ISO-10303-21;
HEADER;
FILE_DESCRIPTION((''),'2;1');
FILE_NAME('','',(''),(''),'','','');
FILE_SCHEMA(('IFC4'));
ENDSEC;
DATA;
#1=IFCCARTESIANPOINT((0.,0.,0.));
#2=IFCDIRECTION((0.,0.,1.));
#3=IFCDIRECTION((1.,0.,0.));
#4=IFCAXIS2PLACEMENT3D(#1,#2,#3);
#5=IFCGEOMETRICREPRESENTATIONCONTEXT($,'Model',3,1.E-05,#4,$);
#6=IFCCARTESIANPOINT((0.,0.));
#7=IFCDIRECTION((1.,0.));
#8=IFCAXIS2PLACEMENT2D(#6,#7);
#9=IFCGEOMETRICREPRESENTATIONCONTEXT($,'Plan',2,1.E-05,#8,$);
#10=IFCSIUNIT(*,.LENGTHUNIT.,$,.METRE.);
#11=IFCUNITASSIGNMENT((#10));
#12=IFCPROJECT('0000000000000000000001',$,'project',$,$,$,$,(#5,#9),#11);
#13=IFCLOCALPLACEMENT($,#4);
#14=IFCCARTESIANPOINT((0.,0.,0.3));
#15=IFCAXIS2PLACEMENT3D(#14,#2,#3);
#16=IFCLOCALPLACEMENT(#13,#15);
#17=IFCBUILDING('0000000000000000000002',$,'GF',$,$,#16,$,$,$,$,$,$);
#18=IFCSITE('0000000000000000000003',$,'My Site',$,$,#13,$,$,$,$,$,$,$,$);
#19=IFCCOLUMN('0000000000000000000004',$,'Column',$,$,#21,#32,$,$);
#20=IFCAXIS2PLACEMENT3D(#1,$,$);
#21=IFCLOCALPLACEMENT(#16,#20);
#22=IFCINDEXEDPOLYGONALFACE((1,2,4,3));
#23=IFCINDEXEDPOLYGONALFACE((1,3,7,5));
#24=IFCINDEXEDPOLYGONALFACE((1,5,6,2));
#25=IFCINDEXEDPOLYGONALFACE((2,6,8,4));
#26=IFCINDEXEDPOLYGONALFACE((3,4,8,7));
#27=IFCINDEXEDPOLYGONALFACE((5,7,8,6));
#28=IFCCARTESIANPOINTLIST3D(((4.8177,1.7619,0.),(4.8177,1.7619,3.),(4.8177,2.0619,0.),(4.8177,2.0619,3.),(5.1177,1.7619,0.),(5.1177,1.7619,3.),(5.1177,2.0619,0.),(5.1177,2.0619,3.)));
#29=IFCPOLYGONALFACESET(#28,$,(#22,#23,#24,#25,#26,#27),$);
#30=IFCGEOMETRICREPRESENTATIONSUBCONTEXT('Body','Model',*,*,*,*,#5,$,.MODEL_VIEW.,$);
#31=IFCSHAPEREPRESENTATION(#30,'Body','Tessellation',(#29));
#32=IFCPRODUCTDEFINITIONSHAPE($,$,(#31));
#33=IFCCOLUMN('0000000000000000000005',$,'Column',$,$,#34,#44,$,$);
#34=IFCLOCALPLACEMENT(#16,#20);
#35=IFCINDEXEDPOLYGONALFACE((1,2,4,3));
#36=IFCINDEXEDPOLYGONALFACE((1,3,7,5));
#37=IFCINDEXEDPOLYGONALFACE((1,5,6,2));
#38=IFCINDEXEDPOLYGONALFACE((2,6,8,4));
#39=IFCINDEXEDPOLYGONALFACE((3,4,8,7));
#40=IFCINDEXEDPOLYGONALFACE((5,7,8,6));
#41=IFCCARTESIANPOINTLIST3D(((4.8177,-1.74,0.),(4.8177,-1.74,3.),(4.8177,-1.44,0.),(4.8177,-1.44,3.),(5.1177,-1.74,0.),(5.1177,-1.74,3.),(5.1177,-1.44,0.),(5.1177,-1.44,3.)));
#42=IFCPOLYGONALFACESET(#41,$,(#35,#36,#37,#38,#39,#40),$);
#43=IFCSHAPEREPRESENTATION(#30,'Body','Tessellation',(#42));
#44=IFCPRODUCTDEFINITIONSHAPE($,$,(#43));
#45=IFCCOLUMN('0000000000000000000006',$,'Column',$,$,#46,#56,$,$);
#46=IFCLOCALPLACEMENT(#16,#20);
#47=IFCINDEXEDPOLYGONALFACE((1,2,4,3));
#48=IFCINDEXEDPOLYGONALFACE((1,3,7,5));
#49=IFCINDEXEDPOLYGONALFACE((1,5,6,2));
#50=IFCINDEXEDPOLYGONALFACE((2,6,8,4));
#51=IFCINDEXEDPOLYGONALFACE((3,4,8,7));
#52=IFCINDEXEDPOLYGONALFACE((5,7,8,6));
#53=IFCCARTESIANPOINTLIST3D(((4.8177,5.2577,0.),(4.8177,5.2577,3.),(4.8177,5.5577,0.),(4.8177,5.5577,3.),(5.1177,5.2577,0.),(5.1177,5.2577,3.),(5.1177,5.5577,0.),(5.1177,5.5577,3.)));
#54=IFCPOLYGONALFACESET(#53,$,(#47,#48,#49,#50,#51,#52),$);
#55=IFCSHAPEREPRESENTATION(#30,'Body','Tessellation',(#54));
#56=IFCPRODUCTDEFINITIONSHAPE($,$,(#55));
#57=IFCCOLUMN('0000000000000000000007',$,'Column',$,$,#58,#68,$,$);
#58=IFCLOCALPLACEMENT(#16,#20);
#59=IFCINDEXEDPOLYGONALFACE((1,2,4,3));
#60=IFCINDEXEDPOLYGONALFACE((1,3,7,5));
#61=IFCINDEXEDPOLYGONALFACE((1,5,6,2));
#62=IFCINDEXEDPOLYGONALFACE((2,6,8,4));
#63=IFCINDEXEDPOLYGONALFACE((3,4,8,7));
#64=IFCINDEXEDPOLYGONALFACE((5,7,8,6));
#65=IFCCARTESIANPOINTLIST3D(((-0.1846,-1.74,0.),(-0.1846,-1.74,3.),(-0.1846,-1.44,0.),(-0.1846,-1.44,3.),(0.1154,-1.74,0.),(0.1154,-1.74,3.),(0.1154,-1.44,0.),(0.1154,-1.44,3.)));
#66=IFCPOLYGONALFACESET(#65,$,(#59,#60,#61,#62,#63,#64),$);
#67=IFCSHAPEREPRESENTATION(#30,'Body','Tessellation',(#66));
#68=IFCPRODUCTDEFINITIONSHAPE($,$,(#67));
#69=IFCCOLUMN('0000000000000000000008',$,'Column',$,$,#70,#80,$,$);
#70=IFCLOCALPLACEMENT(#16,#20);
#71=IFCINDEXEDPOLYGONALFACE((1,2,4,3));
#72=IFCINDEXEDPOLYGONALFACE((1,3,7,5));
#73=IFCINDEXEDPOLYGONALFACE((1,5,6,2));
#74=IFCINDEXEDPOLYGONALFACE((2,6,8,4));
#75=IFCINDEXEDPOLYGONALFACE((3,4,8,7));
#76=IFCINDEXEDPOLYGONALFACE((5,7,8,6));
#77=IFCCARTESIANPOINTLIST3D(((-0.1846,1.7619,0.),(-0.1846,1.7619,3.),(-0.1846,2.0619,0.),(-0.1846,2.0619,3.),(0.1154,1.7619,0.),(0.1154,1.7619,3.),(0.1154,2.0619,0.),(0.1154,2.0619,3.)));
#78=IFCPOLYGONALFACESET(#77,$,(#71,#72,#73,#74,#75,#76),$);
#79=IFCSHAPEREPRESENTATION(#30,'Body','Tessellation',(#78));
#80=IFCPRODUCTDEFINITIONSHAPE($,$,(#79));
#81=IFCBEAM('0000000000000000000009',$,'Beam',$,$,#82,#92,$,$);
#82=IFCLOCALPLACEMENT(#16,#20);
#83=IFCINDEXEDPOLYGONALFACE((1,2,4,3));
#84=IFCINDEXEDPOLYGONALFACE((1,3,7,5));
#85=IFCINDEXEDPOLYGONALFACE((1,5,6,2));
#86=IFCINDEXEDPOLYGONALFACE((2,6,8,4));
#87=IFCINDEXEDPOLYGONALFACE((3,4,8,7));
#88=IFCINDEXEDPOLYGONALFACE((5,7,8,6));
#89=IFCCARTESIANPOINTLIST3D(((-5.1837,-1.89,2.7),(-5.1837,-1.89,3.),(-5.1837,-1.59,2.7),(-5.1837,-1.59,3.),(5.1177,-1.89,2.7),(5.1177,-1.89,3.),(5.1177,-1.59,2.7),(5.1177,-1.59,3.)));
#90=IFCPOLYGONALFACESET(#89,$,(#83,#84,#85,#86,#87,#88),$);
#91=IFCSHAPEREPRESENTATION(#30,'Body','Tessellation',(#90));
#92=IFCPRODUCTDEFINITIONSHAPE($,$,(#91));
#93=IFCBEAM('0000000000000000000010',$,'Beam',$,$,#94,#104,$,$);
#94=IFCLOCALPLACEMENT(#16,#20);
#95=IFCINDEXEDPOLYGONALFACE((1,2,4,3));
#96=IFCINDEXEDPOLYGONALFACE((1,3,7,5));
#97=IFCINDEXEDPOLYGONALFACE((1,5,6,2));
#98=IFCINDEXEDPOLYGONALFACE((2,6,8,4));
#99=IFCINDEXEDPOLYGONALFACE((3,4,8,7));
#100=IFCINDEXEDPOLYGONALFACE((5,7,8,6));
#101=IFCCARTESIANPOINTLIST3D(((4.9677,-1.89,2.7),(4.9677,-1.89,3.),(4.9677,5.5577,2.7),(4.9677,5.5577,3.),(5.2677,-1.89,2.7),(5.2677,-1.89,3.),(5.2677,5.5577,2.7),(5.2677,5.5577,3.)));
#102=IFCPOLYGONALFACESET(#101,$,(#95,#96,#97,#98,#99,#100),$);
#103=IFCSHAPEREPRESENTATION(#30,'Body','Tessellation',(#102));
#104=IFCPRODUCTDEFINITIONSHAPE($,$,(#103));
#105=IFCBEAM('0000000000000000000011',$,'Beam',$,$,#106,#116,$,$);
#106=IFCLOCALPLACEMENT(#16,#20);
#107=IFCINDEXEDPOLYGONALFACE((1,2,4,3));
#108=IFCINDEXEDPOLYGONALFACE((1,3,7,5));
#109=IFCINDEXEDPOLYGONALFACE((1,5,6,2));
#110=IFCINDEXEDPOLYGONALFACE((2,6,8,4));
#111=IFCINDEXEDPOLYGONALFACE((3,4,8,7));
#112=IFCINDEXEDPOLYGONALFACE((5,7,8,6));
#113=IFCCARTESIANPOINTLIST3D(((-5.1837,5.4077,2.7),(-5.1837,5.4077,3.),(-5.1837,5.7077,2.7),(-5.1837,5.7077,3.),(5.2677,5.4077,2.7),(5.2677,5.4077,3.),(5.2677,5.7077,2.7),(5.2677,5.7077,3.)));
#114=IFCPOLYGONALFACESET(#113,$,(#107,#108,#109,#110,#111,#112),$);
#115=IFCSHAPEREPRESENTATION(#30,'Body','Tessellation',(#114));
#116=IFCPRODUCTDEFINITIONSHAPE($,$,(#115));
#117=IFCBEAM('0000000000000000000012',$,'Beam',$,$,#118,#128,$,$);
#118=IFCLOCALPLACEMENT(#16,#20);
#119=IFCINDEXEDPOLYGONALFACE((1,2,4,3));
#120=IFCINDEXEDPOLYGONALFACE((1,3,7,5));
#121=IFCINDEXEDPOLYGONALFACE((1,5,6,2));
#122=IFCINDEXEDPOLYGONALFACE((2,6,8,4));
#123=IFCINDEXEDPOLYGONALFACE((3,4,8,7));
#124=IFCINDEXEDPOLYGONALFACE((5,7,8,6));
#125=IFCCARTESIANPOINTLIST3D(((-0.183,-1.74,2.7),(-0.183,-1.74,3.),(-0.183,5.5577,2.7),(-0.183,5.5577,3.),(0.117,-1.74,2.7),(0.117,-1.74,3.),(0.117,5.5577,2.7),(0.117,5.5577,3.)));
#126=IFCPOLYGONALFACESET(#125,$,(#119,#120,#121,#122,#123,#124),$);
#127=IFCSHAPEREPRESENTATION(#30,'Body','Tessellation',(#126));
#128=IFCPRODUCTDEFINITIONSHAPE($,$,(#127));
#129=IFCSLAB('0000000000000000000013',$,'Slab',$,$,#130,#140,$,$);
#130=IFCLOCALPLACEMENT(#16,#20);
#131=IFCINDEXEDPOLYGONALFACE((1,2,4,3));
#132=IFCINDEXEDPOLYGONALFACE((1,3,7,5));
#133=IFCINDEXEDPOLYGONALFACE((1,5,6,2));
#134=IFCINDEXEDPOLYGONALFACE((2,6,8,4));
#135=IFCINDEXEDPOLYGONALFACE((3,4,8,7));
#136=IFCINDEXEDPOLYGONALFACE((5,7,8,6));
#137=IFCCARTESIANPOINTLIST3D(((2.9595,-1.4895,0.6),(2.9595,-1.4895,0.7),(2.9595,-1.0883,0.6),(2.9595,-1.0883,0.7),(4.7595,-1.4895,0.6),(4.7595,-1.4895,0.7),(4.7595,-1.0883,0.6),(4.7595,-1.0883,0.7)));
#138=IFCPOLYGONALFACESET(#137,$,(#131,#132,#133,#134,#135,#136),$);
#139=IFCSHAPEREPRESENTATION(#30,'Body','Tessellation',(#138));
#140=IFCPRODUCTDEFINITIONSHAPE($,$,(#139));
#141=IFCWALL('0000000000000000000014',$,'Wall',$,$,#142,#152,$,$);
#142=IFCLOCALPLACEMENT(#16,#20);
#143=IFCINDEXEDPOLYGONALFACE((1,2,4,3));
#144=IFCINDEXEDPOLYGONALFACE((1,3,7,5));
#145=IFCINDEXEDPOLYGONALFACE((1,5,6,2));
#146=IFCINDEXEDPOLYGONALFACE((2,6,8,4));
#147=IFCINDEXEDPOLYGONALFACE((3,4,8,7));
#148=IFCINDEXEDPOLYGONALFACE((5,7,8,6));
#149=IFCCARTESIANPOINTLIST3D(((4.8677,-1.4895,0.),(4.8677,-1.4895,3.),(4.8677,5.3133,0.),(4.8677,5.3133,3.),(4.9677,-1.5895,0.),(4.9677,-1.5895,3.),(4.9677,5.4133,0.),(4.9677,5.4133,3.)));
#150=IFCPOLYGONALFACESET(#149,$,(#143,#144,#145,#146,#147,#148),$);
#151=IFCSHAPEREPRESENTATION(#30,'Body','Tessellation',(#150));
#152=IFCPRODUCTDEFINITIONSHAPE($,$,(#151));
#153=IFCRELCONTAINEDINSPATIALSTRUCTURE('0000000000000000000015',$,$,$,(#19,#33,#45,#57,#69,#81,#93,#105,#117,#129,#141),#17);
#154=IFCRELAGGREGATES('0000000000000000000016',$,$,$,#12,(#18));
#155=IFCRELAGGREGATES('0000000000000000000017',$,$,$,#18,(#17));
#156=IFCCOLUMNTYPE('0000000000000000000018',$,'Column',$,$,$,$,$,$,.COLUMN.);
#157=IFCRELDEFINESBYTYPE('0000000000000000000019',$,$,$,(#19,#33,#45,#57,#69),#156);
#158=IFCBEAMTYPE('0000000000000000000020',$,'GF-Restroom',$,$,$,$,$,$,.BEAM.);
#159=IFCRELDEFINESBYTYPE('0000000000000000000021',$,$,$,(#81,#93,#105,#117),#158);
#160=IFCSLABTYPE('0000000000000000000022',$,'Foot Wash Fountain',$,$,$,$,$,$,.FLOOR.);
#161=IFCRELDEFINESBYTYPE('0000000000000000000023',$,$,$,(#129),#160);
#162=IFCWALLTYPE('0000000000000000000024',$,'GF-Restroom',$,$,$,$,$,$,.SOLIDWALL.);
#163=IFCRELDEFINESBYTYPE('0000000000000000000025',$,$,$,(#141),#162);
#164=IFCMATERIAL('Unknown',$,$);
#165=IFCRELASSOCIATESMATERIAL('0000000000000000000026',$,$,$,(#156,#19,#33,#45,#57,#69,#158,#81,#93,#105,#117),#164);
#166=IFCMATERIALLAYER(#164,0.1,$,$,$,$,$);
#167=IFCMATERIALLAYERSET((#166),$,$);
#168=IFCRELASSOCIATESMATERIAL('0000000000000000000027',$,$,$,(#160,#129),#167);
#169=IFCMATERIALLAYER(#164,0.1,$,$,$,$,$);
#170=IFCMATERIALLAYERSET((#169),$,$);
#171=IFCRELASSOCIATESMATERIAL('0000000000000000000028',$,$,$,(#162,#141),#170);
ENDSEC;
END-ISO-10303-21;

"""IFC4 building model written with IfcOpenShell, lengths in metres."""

from ifc_helpers import new_model, si_unit, frame, origin_with_axes, origin_2d_with_axis, place, context, subcontext, project, spatial, line, indexed_curve, rectangle, outline, extrude, material, layer, layer_set, layer_usage, material_profile, profile_set, profile_usage, type_object, element, save


model = new_model("IFC4")

# Units and contexts
model_context = context("Model", 3, precision=1e-05, world=origin_with_axes())
plan_context = context("Plan", 2, precision=1e-05, world=origin_2d_with_axis())
body_context_1 = subcontext(model_context, "Body", "Model", "MODEL_VIEW")
ifc_project = project(units=[si_unit("LENGTHUNIT", "METRE")], contexts=[model_context, plan_context])

# Site, building
site_placement = place(None, origin_with_axes())
site = spatial("IfcSite", under=ifc_project, at=site_placement, Name="My Site")
building_placement = place(site_placement, frame((0.0, 0.0, 0.3), z_axis=(0.0, 0.0, 1.0), x_axis=(1.0, 0.0, 0.0)))
building = spatial("IfcBuilding", under=site, at=building_placement, Name="GF")

# Columns
ifc_material = material(Name="Unknown")
ifc_material_profile_1 = material_profile(ifc_material, rectangle(XDim=0.3, YDim=0.3))
ifc_profile_set_1 = profile_set([ifc_material_profile_1])
ifc_profile_usage_1 = profile_usage(ifc_profile_set_1, cardinal=5)
column_type = type_object("IfcColumnType", Name="Column", PredefinedType="COLUMN", material=ifc_profile_set_1)
column_1_placement = place(building_placement, frame((4.9677, 1.9119, 0.0), z_axis=(0.0, 0.0, 1.0), x_axis=(1.0, 0.0, 0.0)))
element("IfcColumn", 1, at=column_1_placement, inside=building, type_object=column_type, material=ifc_profile_usage_1, Name="Column", context=body_context_1, shape_type="SweptSolid", body=[
    extrude(rectangle(XDim=0.3, YDim=0.3), origin_with_axes(), (0.0, 0.0, 1.0), 3.0),
])
ifc_profile_usage_2 = profile_usage(ifc_profile_set_1, cardinal=5)
column_2_placement = place(building_placement, frame((4.9677, -1.59, 0.0), z_axis=(0.0, 0.0, 1.0), x_axis=(1.0, 0.0, 0.0)))
element("IfcColumn", 2, at=column_2_placement, inside=building, type_object=column_type, material=ifc_profile_usage_2, Name="Column", context=body_context_1, shape_type="SweptSolid", body=[
    extrude(rectangle(XDim=0.3, YDim=0.3), origin_with_axes(), (0.0, 0.0, 1.0), 3.0),
])
ifc_profile_usage_3 = profile_usage(ifc_profile_set_1, cardinal=5)
column_3_placement = place(building_placement, frame((4.9677, 5.4077, 0.0), z_axis=(0.0, 0.0, 1.0), x_axis=(1.0, 0.0, 0.0)))
element("IfcColumn", 3, at=column_3_placement, inside=building, type_object=column_type, material=ifc_profile_usage_3, Name="Column", context=body_context_1, shape_type="SweptSolid", body=[
    extrude(rectangle(XDim=0.3, YDim=0.3), origin_with_axes(), (0.0, 0.0, 1.0), 3.0),
])
ifc_profile_usage_4 = profile_usage(ifc_profile_set_1, cardinal=5)
column_4_placement = place(building_placement, frame((-0.0346, -1.59, 0.0), z_axis=(0.0, 0.0, 1.0), x_axis=(1.0, 0.0, 0.0)))
element("IfcColumn", 4, at=column_4_placement, inside=building, type_object=column_type, material=ifc_profile_usage_4, Name="Column", context=body_context_1, shape_type="SweptSolid", body=[
    extrude(rectangle(XDim=0.3, YDim=0.3), origin_with_axes(), (0.0, 0.0, 1.0), 3.0),
])
ifc_profile_usage_5 = profile_usage(ifc_profile_set_1, cardinal=5)
column_5_placement = place(building_placement, frame((-0.0346, 1.9119, 0.0), z_axis=(0.0, 0.0, 1.0), x_axis=(1.0, 0.0, 0.0)))
element("IfcColumn", 5, at=column_5_placement, inside=building, type_object=column_type, material=ifc_profile_usage_5, Name="Column", context=body_context_1, shape_type="SweptSolid", body=[
    extrude(rectangle(XDim=0.3, YDim=0.3), origin_with_axes(), (0.0, 0.0, 1.0), 3.0),
])

# Beams
ifc_material_profile_2 = material_profile(ifc_material, rectangle(XDim=0.3, YDim=0.3))
ifc_profile_set_2 = profile_set([ifc_material_profile_2])
ifc_profile_usage_6 = profile_usage(ifc_profile_set_2, cardinal=8)
beam_type = type_object("IfcBeamType", Name="GF-Restroom", PredefinedType="BEAM", material=ifc_profile_set_2)
beam_1_placement = place(building_placement, frame((5.1177, -1.74, 3.0), z_axis=(-1.0, 0.0, 0.0), x_axis=(0.0, -1.0, 0.0)))
element("IfcBeam", 6, at=beam_1_placement, inside=building, type_object=beam_type, material=ifc_profile_usage_6, Name="Beam", context=body_context_1, shape_type="SweptSolid", body=[
    extrude(rectangle(XDim=0.3, YDim=0.3), frame((0.0, -0.15, 0.0), z_axis=(0.0, 0.0, 1.0), x_axis=(1.0, 0.0, 0.0)), (0.0, 0.0, 1.0), 10.3015),
])
ifc_profile_usage_7 = profile_usage(ifc_profile_set_2, cardinal=8)
beam_2_placement = place(building_placement, frame((5.1177, -1.89, 3.0), z_axis=(0.0, 1.0, 0.0), x_axis=(-1.0, 0.0, 0.0)))
element("IfcBeam", 7, at=beam_2_placement, inside=building, type_object=beam_type, material=ifc_profile_usage_7, Name="Beam", context=body_context_1, shape_type="SweptSolid", body=[
    extrude(rectangle(XDim=0.3, YDim=0.3), frame((0.0, -0.15, 0.0), z_axis=(0.0, 0.0, 1.0), x_axis=(1.0, 0.0, 0.0)), (0.0, 0.0, 1.0), 7.4477),
])
ifc_profile_usage_8 = profile_usage(ifc_profile_set_2, cardinal=8)
beam_3_placement = place(building_placement, frame((5.2677, 5.5577, 3.0), z_axis=(-1.0, 0.0, 0.0), x_axis=(0.0, -1.0, 0.0)))
element("IfcBeam", 8, at=beam_3_placement, inside=building, type_object=beam_type, material=ifc_profile_usage_8, Name="Beam", context=body_context_1, shape_type="SweptSolid", body=[
    extrude(rectangle(XDim=0.3, YDim=0.3), frame((0.0, -0.15, 0.0), z_axis=(0.0, 0.0, 1.0), x_axis=(1.0, 0.0, 0.0)), (0.0, 0.0, 1.0), 10.4515),
])
ifc_profile_usage_9 = profile_usage(ifc_profile_set_2, cardinal=8)
beam_4_placement = place(building_placement, frame((-0.033, -1.74, 3.0), z_axis=(0.0, 1.0, 0.0), x_axis=(-1.0, 0.0, 0.0)))
element("IfcBeam", 9, at=beam_4_placement, inside=building, type_object=beam_type, material=ifc_profile_usage_9, Name="Beam", context=body_context_1, shape_type="SweptSolid", body=[
    extrude(rectangle(XDim=0.3, YDim=0.3), frame((0.0, -0.15, 0.0), z_axis=(0.0, 0.0, 1.0), x_axis=(1.0, 0.0, 0.0)), (0.0, 0.0, 1.0), 7.2977),
])

# Slab
ifc_layer_1 = layer(ifc_material, 0.1)
ifc_layer_set_1 = layer_set([ifc_layer_1])
slab_type_1 = type_object("IfcSlabType", Name="Foot Wash Fountain", PredefinedType="FLOOR", material=ifc_layer_set_1)
ifc_layer_usage_1 = layer_usage(ifc_layer_set_1, "AXIS3", "POSITIVE", -0.3)
slab_1_placement = place(building_placement, frame((2.9595, -1.4895, 0.9), z_axis=(0.0, 0.0, 1.0), x_axis=(1.0, 0.0, 0.0)))
element("IfcSlab", 10, at=slab_1_placement, inside=building, type_object=slab_type_1, material=ifc_layer_usage_1, Name="Slab", context=body_context_1, shape_type="SweptSolid", body=[
    extrude(outline(indexed_curve([(0.0, 0.0), (0.0, 0.4011), (1.8, 0.4011), (1.8, 0.0), (0.0, 0.0)])), frame((0.0, 0.0, -0.3), z_axis=(0.0, 0.0, 1.0), x_axis=(1.0, 0.0, 0.0)), (0.0, 0.0, 1.0), 0.1),
])

# Wall
ifc_layer_2 = layer(ifc_material, 0.1)
ifc_layer_set_2 = layer_set([ifc_layer_2])
ifc_layer_usage_2 = layer_usage(ifc_layer_set_2, "AXIS2", "POSITIVE", 0.0)
wall_type_1 = type_object("IfcWallType", Name="GF-Restroom", PredefinedType="SOLIDWALL", material=ifc_layer_set_2)
wall_1_placement = place(building_placement, frame((4.9677, -1.5895, 0.0), z_axis=(0.0, 0.0, 1.0), x_axis=(0.0, 1.0, 0.0)))
element("IfcWall", 11, at=wall_1_placement, inside=building, type_object=wall_type_1, material=ifc_layer_usage_2, Name="Wall", context=body_context_1, shape_type="SweptSolid", body=[
    extrude(outline(indexed_curve([(0.0, 0.0), (0.1, 0.1), (6.9028, 0.1), (7.0028, 0.0)], segments=[line(1, 2, 3, 4, 1)])), origin_with_axes(), (0.0, 0.0, 1.0), 3.0),
])

save(model, "model.ifc")
